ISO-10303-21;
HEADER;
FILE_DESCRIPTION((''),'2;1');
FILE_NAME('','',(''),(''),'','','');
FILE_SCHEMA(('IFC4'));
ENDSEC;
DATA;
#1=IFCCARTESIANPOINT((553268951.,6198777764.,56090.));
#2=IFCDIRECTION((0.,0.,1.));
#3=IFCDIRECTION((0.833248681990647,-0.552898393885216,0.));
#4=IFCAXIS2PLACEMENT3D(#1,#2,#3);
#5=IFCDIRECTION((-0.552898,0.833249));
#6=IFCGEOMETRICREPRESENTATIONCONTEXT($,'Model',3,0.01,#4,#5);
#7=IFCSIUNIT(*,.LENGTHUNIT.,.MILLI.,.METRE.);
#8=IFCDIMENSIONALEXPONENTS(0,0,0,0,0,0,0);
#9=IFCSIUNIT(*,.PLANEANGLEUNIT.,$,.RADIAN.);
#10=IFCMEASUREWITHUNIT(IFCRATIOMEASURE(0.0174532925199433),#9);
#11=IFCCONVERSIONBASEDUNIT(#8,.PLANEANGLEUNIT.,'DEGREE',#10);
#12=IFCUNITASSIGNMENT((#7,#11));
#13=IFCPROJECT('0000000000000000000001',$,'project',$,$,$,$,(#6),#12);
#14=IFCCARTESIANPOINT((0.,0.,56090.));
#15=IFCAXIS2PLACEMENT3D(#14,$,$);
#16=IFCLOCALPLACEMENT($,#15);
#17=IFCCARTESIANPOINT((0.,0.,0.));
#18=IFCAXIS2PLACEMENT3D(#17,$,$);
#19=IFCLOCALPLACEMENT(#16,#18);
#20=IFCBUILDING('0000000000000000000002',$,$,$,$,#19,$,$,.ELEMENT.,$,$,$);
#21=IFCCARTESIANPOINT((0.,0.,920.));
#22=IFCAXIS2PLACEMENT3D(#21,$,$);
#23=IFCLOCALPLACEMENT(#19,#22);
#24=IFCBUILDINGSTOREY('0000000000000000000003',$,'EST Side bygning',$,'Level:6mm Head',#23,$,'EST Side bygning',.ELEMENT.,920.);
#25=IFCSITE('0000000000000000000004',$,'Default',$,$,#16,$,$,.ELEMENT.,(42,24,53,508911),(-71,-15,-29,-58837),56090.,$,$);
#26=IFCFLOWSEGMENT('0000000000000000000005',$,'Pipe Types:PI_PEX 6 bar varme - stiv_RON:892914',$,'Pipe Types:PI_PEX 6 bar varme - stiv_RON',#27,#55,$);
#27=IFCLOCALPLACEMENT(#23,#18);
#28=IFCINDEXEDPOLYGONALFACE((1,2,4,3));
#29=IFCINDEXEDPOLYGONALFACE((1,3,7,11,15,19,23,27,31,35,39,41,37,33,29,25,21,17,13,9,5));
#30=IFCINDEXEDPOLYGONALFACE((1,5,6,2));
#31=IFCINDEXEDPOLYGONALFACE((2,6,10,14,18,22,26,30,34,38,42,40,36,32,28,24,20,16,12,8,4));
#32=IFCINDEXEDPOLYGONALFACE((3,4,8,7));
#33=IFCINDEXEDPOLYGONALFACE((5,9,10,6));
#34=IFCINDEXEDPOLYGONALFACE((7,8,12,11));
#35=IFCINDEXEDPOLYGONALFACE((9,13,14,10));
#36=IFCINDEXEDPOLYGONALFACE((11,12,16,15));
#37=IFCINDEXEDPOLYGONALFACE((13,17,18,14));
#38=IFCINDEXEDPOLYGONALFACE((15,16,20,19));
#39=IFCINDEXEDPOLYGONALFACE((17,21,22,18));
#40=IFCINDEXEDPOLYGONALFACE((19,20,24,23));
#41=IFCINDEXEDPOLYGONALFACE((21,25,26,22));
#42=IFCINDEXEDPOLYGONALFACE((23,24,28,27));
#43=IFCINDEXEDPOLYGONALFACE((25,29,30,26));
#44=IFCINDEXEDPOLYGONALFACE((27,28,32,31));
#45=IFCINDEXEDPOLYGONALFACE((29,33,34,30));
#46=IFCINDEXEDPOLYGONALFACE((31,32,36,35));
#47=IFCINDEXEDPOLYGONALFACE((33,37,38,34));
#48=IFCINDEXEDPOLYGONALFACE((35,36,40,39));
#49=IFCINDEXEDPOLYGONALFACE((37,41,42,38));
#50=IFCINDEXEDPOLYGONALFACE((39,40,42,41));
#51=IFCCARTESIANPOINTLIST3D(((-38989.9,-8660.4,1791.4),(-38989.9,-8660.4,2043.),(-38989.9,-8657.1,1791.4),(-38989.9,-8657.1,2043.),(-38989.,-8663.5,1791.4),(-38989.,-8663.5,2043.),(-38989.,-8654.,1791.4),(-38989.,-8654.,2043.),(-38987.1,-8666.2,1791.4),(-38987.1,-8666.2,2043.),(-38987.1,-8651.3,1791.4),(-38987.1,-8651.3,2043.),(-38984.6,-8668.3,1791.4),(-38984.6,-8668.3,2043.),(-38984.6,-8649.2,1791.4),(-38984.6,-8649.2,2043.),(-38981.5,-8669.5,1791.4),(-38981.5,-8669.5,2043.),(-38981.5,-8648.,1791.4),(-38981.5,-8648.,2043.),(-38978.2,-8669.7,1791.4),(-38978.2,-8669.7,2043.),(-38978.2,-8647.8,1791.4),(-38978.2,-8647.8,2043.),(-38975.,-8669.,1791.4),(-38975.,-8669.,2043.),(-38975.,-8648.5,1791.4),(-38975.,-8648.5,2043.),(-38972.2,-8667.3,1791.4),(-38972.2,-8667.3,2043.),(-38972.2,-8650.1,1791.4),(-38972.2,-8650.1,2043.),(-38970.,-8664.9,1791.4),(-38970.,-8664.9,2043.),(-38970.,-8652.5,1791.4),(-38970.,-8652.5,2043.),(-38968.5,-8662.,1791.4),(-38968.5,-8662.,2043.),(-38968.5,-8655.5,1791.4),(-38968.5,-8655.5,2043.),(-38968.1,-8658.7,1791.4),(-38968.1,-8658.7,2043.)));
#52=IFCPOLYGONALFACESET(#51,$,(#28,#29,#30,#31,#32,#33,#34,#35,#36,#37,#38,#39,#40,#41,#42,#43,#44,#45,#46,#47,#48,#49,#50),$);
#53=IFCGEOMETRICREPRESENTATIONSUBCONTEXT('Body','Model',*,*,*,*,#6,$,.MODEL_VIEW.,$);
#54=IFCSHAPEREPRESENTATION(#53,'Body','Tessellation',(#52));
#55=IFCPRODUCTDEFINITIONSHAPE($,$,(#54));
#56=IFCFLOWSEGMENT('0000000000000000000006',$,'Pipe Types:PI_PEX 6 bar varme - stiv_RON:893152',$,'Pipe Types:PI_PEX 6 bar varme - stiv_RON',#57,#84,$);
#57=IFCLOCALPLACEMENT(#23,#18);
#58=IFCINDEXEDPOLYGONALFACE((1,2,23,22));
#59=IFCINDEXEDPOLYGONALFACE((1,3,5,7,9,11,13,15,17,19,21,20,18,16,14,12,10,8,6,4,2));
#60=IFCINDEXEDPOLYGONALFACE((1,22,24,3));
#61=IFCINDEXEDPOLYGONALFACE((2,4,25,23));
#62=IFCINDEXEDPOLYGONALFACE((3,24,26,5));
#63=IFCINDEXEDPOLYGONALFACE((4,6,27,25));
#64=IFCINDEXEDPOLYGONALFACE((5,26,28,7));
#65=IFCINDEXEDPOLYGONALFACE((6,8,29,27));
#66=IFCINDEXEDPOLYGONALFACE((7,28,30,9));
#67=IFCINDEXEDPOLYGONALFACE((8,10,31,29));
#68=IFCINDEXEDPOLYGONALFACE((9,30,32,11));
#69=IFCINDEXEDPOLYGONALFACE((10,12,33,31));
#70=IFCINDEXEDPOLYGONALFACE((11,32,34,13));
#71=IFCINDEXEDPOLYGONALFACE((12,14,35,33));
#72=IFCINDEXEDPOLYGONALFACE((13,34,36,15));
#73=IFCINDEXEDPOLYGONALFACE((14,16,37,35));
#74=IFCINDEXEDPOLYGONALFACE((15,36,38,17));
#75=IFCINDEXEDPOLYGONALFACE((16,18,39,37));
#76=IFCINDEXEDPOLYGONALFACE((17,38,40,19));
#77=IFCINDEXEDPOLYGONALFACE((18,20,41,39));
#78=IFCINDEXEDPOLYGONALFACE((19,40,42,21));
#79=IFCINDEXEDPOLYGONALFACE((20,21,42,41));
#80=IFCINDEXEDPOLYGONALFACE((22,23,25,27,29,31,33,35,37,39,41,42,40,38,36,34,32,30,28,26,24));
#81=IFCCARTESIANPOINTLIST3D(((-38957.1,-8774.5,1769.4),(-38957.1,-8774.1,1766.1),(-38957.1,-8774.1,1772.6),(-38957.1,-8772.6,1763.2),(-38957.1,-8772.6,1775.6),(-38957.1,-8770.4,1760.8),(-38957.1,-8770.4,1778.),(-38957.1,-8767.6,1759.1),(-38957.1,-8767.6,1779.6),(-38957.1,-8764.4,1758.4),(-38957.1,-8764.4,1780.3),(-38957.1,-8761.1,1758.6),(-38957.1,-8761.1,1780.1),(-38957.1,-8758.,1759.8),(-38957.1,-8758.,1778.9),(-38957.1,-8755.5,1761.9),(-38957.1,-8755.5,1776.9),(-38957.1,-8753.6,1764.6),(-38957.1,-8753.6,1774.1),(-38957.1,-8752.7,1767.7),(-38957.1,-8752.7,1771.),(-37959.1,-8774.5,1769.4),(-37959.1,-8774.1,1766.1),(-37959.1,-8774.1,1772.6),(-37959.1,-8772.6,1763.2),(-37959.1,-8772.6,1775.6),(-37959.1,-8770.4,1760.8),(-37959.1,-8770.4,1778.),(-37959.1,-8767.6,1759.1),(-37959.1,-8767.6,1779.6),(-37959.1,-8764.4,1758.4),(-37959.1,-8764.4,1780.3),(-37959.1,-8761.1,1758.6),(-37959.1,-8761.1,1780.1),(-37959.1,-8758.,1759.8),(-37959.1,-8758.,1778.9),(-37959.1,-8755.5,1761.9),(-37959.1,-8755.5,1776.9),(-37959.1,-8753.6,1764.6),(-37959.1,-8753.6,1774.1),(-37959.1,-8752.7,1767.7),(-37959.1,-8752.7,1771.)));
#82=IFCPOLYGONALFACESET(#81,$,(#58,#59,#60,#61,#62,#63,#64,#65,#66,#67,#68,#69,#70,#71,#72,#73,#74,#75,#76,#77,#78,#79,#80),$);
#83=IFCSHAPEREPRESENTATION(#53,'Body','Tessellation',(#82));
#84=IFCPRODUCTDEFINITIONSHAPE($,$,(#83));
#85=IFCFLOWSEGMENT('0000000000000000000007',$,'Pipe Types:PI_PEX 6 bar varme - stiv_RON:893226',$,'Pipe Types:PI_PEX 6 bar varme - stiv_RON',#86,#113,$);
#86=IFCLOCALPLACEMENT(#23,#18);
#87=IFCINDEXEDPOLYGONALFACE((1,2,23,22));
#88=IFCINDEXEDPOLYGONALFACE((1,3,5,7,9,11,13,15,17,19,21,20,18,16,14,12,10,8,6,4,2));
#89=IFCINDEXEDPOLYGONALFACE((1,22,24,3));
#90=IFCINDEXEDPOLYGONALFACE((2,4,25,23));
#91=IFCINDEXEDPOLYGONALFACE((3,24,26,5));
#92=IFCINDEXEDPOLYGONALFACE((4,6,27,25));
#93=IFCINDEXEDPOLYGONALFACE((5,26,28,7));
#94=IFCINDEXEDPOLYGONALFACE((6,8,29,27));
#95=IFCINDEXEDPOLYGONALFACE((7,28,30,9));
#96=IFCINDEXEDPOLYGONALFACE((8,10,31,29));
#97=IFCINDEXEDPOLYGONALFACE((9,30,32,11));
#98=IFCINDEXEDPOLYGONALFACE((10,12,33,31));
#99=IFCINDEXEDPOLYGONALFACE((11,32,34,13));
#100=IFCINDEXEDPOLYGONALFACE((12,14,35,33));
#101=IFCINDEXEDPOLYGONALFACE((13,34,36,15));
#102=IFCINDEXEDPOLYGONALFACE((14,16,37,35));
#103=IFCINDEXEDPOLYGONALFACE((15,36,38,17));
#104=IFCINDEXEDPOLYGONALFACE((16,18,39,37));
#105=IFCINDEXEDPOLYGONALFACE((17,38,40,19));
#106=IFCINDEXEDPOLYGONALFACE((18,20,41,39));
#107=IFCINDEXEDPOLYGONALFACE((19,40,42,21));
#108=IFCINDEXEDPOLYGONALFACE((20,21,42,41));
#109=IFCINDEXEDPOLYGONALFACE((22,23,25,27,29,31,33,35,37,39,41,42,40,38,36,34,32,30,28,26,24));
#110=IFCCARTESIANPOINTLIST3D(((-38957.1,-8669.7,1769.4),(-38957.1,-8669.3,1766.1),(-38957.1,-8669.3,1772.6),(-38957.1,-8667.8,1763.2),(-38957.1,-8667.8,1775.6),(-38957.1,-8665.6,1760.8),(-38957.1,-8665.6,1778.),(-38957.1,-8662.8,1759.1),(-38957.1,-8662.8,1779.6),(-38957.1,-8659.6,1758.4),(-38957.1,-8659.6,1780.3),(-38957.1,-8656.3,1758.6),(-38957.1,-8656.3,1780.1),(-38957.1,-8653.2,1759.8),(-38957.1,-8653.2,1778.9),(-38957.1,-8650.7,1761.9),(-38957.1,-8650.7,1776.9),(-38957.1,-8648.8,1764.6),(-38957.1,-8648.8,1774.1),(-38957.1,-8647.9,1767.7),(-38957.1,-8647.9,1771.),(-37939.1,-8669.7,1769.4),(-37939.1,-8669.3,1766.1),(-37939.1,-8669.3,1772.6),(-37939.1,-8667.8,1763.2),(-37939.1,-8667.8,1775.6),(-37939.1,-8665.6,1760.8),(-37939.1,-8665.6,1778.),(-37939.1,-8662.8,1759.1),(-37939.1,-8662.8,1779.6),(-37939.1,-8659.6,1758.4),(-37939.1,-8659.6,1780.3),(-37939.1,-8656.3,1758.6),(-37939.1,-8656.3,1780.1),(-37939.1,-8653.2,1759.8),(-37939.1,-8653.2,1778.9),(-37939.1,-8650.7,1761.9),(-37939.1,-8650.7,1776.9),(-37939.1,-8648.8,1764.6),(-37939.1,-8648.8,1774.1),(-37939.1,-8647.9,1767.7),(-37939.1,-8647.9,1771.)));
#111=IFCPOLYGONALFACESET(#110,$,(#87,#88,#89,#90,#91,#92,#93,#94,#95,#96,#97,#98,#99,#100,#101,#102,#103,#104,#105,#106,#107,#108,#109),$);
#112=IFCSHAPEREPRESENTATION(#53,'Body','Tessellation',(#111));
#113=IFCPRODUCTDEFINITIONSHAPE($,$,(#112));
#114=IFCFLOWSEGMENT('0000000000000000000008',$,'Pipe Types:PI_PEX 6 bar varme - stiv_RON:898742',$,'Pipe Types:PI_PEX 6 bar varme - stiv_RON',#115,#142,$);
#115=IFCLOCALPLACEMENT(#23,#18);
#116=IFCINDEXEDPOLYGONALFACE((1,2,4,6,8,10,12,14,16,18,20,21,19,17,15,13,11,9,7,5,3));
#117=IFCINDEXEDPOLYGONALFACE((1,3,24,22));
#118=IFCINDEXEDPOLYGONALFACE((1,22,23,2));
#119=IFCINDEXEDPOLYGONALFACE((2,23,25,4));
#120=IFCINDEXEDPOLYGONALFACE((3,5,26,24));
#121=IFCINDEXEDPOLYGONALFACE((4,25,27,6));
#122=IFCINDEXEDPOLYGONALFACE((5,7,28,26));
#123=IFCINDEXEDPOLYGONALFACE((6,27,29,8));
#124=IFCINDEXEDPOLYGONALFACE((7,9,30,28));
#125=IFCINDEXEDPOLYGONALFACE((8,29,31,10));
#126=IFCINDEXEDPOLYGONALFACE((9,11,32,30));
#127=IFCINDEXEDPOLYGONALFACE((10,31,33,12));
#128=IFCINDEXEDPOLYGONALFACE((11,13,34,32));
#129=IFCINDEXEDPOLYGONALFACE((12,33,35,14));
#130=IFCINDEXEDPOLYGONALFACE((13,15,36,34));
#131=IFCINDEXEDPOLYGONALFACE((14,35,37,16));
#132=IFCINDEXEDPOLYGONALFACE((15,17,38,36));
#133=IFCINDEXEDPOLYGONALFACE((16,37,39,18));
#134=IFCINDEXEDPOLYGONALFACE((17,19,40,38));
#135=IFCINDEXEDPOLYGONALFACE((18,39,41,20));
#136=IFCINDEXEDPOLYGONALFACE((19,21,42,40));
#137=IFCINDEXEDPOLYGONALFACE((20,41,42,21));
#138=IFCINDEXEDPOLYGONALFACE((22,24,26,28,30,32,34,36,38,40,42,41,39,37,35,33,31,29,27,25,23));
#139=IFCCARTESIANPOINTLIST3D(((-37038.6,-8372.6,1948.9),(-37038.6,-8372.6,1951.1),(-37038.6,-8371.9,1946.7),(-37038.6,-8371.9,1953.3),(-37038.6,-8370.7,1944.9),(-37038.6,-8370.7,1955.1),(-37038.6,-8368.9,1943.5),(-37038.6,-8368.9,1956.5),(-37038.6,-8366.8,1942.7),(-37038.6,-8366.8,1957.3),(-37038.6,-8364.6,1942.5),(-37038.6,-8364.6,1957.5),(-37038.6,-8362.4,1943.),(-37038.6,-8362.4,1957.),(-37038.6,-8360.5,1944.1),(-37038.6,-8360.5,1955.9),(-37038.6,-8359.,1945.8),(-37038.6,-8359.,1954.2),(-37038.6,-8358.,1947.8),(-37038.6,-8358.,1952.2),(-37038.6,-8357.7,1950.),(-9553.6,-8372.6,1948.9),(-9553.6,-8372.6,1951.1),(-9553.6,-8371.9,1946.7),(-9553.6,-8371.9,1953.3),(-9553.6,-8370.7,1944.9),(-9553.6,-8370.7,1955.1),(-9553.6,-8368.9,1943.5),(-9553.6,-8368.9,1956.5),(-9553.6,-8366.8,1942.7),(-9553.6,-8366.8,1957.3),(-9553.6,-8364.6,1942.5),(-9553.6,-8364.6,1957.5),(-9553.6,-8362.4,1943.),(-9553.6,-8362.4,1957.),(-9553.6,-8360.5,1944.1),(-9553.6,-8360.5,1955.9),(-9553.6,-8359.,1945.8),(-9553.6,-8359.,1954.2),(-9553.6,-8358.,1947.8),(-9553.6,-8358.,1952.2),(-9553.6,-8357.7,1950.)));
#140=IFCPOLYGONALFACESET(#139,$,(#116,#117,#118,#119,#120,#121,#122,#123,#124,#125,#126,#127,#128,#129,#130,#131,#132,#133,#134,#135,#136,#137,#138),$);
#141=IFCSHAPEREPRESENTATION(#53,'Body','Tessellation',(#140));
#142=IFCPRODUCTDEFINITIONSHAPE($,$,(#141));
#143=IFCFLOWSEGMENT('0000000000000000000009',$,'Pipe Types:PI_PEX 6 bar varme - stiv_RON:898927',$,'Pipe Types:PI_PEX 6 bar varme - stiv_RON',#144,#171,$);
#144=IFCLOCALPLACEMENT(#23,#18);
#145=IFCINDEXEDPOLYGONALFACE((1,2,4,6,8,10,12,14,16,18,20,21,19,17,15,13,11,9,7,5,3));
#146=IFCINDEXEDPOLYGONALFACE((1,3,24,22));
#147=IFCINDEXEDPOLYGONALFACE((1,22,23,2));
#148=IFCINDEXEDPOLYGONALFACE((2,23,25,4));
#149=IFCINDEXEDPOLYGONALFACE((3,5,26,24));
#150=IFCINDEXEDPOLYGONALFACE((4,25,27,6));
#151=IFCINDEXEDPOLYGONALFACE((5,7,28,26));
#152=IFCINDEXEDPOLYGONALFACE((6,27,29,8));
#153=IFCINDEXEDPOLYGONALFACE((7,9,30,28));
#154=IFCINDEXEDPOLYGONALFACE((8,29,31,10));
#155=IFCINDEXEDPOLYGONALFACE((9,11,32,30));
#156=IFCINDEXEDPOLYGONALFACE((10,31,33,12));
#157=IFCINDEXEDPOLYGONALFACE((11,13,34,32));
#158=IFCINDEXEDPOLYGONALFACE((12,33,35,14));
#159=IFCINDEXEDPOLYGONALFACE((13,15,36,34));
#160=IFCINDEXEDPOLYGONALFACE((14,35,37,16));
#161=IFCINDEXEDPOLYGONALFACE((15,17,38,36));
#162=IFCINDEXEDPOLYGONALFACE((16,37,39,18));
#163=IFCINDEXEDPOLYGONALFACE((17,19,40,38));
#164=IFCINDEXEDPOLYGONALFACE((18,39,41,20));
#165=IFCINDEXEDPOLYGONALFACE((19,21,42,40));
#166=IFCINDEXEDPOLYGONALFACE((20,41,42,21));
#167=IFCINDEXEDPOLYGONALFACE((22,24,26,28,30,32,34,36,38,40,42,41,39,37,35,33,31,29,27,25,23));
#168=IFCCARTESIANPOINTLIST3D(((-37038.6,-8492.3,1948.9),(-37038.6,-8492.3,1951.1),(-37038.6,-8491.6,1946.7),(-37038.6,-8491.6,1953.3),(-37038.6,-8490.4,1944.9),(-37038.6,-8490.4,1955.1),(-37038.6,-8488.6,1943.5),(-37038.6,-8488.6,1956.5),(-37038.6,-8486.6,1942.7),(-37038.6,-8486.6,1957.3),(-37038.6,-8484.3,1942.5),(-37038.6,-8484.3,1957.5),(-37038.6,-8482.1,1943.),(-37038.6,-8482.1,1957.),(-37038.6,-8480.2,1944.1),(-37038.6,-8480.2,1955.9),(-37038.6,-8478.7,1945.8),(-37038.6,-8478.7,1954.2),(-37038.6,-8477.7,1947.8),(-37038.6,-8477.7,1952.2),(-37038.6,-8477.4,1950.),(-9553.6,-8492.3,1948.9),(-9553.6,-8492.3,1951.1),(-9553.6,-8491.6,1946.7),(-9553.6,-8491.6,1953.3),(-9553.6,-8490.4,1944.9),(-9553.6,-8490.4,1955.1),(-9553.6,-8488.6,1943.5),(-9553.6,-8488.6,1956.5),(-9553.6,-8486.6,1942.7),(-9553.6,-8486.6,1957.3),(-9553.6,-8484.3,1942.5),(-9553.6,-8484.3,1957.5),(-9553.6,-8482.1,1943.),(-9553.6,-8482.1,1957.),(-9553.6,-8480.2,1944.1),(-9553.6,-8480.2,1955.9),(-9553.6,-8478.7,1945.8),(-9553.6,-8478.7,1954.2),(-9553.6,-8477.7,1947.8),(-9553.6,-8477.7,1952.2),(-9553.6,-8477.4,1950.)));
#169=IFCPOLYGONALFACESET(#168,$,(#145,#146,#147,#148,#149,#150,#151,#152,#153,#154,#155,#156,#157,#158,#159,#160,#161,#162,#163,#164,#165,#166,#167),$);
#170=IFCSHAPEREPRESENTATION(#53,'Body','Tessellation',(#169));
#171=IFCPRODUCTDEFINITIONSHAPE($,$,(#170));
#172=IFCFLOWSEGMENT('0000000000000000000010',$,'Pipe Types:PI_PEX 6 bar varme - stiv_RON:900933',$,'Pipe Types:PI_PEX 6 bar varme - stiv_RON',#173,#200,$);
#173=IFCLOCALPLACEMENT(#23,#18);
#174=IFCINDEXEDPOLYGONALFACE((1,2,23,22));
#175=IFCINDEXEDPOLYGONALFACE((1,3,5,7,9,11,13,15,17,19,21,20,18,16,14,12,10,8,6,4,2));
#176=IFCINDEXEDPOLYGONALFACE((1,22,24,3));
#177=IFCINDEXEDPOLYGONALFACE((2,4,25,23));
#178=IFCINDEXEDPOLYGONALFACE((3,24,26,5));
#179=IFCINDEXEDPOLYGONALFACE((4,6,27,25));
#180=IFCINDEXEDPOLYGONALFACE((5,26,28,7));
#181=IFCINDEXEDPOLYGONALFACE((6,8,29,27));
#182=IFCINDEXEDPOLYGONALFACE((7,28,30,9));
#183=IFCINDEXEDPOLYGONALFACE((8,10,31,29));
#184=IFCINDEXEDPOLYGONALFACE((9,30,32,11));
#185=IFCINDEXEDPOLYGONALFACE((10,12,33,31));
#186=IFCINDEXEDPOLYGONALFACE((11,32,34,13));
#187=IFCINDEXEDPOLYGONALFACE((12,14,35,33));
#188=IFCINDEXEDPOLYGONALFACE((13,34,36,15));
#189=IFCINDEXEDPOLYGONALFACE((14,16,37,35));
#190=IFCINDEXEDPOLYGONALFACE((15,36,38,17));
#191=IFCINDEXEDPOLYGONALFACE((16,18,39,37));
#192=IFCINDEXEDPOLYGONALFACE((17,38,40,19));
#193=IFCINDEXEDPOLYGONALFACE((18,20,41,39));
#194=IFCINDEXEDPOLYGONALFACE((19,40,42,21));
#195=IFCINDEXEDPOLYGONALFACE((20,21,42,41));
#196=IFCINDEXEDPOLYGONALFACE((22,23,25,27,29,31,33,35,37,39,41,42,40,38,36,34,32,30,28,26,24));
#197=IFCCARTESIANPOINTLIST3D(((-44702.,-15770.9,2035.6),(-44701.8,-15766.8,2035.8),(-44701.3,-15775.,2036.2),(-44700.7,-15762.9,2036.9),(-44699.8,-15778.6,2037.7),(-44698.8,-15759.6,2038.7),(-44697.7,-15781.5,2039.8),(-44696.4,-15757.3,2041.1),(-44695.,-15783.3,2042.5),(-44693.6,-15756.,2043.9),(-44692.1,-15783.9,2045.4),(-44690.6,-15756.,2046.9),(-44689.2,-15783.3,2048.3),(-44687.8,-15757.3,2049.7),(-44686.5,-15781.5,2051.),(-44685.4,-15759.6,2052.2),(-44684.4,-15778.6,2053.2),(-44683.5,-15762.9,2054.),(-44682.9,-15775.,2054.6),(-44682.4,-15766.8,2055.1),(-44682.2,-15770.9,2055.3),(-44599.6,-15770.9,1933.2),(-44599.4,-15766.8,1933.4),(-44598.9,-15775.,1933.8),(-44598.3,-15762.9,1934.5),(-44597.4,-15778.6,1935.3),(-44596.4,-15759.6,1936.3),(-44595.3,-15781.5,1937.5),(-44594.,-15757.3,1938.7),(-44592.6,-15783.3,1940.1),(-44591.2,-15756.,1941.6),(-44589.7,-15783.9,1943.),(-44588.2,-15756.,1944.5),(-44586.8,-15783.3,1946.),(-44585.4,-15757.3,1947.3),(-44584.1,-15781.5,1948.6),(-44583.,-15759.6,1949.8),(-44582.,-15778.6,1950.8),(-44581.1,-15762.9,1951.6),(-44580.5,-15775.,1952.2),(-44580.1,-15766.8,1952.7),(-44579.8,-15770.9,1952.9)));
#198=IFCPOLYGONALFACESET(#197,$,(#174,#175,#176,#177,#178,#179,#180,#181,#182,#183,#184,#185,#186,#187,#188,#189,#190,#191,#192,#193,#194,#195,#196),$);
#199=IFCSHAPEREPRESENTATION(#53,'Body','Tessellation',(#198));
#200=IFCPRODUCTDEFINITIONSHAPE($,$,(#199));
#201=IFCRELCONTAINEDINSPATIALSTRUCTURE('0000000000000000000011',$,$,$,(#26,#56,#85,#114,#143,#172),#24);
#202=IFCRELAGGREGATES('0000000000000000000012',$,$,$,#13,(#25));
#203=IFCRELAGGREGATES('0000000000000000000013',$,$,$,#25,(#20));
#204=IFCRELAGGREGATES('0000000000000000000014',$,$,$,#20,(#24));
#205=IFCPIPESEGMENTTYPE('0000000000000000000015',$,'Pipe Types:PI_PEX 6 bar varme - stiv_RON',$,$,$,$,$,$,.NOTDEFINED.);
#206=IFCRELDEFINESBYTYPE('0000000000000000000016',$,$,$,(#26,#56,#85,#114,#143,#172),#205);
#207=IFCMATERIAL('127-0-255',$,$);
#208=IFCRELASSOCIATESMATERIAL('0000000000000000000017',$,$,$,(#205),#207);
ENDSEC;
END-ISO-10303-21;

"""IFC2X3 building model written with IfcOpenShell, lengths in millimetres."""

from ifc_helpers import new_model, entity, si_unit, converted_unit, direction, frame, frame_2d, origin, origin_2d_with_axis, place, context, subcontext, project, spatial, circle, extrude, material, type_object, element, save


model = new_model("IFC2X3")

# Units and contexts
model_context = context("Model", 3, precision=0.01, world=frame((553268951.0, 6198777764.0, 56090.0), z_axis=(0.0, 0.0, 1.0), x_axis=(0.833248681990647, -0.552898393885216, 0.0)), true_north=direction((-0.552898, 0.833249)))
body_context = subcontext(model_context, "Body", "Model", "MODEL_VIEW")
ifc_project = project(units=[si_unit("LENGTHUNIT", "METRE", prefix="MILLI"), converted_unit("PLANEANGLEUNIT", "DEGREE", entity("IfcRatioMeasure", 0.0174532925199433), si_unit("PLANEANGLEUNIT", "RADIAN"), dimensions=[0, 0, 0, 0, 0, 0, 0])], contexts=[model_context])

# Site, building, storey
site_placement = place(None, frame((0.0, 0.0, 56090.0)))
site = spatial("IfcSite", under=ifc_project, at=site_placement, Name="Default", CompositionType="ELEMENT", RefLatitude=(42, 24, 53, 508911), RefLongitude=(-71, -15, -29, -58837), RefElevation=56090.0)
building_placement = place(site_placement, origin())
building = spatial("IfcBuilding", under=site, at=building_placement, CompositionType="ELEMENT")
storey_placement = place(building_placement, frame((0.0, 0.0, 920.0)))
storey = spatial("IfcBuildingStorey", under=building, at=storey_placement, Name="EST Side bygning", ObjectType="Level:6mm Head", LongName="EST Side bygning", CompositionType="ELEMENT", Elevation=920.0)

# Flow segments
ifc_material_1 = material(Name="127-0-255")
pipe_segment_type_1 = type_object("IfcPipeSegmentType", Name="Pipe Types:PI_PEX 6 bar varme - stiv_RON", PredefinedType="NOTDEFINED", material=ifc_material_1)
flow_segment_1_placement = place(storey_placement, origin())
element("IfcFlowSegment", 1, at=flow_segment_1_placement, inside=storey, type_object=pipe_segment_type_1, Name="Pipe Types:PI_PEX 6 bar varme - stiv_RON:892914", ObjectType="Pipe Types:PI_PEX 6 bar varme - stiv_RON", context=body_context, shape_type="SweptSolid", body=[
    extrude(circle(Radius=11.0, at=origin_2d_with_axis()), frame((-38979.1, -8658.7, 1791.4)), (0.0, 0.0, 1.0), 251.6),
])
flow_segment_2_placement = place(storey_placement, origin())
element("IfcFlowSegment", 2, at=flow_segment_2_placement, inside=storey, type_object=pipe_segment_type_1, Name="Pipe Types:PI_PEX 6 bar varme - stiv_RON:893152", ObjectType="Pipe Types:PI_PEX 6 bar varme - stiv_RON", context=body_context, shape_type="SweptSolid", body=[
    extrude(circle(Radius=11.0, at=origin_2d_with_axis()), frame((-38957.1, -8763.5, 1769.4), z_axis=(1.0, 0.0, 0.0), x_axis=(0.0, -1.0, 0.0)), (0.0, 0.0, 1.0), 998.0),
])
flow_segment_3_placement = place(storey_placement, origin())
element("IfcFlowSegment", 3, at=flow_segment_3_placement, inside=storey, type_object=pipe_segment_type_1, Name="Pipe Types:PI_PEX 6 bar varme - stiv_RON:893226", ObjectType="Pipe Types:PI_PEX 6 bar varme - stiv_RON", context=body_context, shape_type="SweptSolid", body=[
    extrude(circle(Radius=11.0, at=origin_2d_with_axis()), frame((-38957.1, -8658.7, 1769.4), z_axis=(1.0, 0.0, 0.0), x_axis=(0.0, -1.0, 0.0)), (0.0, 0.0, 1.0), 1018.0),
])
flow_segment_4_placement = place(storey_placement, origin())
element("IfcFlowSegment", 4, at=flow_segment_4_placement, inside=storey, type_object=pipe_segment_type_1, Name="Pipe Types:PI_PEX 6 bar varme - stiv_RON:898742", ObjectType="Pipe Types:PI_PEX 6 bar varme - stiv_RON", context=body_context, shape_type="SweptSolid", body=[
    extrude(circle(Radius=7.5, at=origin_2d_with_axis()), frame((-37038.6, -8365.2, 1950.0), z_axis=(1.0, 0.0, 0.0), x_axis=(0.0, 1.0, 0.0)), (0.0, 0.0, 1.0), 27485.0),
])
flow_segment_5_placement = place(storey_placement, origin())
element("IfcFlowSegment", 5, at=flow_segment_5_placement, inside=storey, type_object=pipe_segment_type_1, Name="Pipe Types:PI_PEX 6 bar varme - stiv_RON:898927", ObjectType="Pipe Types:PI_PEX 6 bar varme - stiv_RON", context=body_context, shape_type="SweptSolid", body=[
    extrude(circle(Radius=7.5, at=frame_2d((0.0, 0.0), x_axis=(1.0, 0.0))), frame((-37038.6, -8484.9, 1950.0), z_axis=(1.0, 0.0, 0.0), x_axis=(0.0, 1.0, 0.0)), (0.0, 0.0, 1.0), 27485.0),
])
flow_segment_6_placement = place(storey_placement, origin())
element("IfcFlowSegment", 6, at=flow_segment_6_placement, inside=storey, type_object=pipe_segment_type_1, Name="Pipe Types:PI_PEX 6 bar varme - stiv_RON:900933", ObjectType="Pipe Types:PI_PEX 6 bar varme - stiv_RON", context=body_context, shape_type="SweptSolid", body=[
    extrude(circle(Radius=14.0, at=frame_2d((0.0, 0.0), x_axis=(1.0, 0.0))), frame((-44589.7, -15769.9, 1943.0), z_axis=(-0.707107, 0.0, 0.707107), x_axis=(0.0, -1.0, 0.0)), (0.0, 0.0, 1.0), 144.8),
])

save(model, "model.ifc")
